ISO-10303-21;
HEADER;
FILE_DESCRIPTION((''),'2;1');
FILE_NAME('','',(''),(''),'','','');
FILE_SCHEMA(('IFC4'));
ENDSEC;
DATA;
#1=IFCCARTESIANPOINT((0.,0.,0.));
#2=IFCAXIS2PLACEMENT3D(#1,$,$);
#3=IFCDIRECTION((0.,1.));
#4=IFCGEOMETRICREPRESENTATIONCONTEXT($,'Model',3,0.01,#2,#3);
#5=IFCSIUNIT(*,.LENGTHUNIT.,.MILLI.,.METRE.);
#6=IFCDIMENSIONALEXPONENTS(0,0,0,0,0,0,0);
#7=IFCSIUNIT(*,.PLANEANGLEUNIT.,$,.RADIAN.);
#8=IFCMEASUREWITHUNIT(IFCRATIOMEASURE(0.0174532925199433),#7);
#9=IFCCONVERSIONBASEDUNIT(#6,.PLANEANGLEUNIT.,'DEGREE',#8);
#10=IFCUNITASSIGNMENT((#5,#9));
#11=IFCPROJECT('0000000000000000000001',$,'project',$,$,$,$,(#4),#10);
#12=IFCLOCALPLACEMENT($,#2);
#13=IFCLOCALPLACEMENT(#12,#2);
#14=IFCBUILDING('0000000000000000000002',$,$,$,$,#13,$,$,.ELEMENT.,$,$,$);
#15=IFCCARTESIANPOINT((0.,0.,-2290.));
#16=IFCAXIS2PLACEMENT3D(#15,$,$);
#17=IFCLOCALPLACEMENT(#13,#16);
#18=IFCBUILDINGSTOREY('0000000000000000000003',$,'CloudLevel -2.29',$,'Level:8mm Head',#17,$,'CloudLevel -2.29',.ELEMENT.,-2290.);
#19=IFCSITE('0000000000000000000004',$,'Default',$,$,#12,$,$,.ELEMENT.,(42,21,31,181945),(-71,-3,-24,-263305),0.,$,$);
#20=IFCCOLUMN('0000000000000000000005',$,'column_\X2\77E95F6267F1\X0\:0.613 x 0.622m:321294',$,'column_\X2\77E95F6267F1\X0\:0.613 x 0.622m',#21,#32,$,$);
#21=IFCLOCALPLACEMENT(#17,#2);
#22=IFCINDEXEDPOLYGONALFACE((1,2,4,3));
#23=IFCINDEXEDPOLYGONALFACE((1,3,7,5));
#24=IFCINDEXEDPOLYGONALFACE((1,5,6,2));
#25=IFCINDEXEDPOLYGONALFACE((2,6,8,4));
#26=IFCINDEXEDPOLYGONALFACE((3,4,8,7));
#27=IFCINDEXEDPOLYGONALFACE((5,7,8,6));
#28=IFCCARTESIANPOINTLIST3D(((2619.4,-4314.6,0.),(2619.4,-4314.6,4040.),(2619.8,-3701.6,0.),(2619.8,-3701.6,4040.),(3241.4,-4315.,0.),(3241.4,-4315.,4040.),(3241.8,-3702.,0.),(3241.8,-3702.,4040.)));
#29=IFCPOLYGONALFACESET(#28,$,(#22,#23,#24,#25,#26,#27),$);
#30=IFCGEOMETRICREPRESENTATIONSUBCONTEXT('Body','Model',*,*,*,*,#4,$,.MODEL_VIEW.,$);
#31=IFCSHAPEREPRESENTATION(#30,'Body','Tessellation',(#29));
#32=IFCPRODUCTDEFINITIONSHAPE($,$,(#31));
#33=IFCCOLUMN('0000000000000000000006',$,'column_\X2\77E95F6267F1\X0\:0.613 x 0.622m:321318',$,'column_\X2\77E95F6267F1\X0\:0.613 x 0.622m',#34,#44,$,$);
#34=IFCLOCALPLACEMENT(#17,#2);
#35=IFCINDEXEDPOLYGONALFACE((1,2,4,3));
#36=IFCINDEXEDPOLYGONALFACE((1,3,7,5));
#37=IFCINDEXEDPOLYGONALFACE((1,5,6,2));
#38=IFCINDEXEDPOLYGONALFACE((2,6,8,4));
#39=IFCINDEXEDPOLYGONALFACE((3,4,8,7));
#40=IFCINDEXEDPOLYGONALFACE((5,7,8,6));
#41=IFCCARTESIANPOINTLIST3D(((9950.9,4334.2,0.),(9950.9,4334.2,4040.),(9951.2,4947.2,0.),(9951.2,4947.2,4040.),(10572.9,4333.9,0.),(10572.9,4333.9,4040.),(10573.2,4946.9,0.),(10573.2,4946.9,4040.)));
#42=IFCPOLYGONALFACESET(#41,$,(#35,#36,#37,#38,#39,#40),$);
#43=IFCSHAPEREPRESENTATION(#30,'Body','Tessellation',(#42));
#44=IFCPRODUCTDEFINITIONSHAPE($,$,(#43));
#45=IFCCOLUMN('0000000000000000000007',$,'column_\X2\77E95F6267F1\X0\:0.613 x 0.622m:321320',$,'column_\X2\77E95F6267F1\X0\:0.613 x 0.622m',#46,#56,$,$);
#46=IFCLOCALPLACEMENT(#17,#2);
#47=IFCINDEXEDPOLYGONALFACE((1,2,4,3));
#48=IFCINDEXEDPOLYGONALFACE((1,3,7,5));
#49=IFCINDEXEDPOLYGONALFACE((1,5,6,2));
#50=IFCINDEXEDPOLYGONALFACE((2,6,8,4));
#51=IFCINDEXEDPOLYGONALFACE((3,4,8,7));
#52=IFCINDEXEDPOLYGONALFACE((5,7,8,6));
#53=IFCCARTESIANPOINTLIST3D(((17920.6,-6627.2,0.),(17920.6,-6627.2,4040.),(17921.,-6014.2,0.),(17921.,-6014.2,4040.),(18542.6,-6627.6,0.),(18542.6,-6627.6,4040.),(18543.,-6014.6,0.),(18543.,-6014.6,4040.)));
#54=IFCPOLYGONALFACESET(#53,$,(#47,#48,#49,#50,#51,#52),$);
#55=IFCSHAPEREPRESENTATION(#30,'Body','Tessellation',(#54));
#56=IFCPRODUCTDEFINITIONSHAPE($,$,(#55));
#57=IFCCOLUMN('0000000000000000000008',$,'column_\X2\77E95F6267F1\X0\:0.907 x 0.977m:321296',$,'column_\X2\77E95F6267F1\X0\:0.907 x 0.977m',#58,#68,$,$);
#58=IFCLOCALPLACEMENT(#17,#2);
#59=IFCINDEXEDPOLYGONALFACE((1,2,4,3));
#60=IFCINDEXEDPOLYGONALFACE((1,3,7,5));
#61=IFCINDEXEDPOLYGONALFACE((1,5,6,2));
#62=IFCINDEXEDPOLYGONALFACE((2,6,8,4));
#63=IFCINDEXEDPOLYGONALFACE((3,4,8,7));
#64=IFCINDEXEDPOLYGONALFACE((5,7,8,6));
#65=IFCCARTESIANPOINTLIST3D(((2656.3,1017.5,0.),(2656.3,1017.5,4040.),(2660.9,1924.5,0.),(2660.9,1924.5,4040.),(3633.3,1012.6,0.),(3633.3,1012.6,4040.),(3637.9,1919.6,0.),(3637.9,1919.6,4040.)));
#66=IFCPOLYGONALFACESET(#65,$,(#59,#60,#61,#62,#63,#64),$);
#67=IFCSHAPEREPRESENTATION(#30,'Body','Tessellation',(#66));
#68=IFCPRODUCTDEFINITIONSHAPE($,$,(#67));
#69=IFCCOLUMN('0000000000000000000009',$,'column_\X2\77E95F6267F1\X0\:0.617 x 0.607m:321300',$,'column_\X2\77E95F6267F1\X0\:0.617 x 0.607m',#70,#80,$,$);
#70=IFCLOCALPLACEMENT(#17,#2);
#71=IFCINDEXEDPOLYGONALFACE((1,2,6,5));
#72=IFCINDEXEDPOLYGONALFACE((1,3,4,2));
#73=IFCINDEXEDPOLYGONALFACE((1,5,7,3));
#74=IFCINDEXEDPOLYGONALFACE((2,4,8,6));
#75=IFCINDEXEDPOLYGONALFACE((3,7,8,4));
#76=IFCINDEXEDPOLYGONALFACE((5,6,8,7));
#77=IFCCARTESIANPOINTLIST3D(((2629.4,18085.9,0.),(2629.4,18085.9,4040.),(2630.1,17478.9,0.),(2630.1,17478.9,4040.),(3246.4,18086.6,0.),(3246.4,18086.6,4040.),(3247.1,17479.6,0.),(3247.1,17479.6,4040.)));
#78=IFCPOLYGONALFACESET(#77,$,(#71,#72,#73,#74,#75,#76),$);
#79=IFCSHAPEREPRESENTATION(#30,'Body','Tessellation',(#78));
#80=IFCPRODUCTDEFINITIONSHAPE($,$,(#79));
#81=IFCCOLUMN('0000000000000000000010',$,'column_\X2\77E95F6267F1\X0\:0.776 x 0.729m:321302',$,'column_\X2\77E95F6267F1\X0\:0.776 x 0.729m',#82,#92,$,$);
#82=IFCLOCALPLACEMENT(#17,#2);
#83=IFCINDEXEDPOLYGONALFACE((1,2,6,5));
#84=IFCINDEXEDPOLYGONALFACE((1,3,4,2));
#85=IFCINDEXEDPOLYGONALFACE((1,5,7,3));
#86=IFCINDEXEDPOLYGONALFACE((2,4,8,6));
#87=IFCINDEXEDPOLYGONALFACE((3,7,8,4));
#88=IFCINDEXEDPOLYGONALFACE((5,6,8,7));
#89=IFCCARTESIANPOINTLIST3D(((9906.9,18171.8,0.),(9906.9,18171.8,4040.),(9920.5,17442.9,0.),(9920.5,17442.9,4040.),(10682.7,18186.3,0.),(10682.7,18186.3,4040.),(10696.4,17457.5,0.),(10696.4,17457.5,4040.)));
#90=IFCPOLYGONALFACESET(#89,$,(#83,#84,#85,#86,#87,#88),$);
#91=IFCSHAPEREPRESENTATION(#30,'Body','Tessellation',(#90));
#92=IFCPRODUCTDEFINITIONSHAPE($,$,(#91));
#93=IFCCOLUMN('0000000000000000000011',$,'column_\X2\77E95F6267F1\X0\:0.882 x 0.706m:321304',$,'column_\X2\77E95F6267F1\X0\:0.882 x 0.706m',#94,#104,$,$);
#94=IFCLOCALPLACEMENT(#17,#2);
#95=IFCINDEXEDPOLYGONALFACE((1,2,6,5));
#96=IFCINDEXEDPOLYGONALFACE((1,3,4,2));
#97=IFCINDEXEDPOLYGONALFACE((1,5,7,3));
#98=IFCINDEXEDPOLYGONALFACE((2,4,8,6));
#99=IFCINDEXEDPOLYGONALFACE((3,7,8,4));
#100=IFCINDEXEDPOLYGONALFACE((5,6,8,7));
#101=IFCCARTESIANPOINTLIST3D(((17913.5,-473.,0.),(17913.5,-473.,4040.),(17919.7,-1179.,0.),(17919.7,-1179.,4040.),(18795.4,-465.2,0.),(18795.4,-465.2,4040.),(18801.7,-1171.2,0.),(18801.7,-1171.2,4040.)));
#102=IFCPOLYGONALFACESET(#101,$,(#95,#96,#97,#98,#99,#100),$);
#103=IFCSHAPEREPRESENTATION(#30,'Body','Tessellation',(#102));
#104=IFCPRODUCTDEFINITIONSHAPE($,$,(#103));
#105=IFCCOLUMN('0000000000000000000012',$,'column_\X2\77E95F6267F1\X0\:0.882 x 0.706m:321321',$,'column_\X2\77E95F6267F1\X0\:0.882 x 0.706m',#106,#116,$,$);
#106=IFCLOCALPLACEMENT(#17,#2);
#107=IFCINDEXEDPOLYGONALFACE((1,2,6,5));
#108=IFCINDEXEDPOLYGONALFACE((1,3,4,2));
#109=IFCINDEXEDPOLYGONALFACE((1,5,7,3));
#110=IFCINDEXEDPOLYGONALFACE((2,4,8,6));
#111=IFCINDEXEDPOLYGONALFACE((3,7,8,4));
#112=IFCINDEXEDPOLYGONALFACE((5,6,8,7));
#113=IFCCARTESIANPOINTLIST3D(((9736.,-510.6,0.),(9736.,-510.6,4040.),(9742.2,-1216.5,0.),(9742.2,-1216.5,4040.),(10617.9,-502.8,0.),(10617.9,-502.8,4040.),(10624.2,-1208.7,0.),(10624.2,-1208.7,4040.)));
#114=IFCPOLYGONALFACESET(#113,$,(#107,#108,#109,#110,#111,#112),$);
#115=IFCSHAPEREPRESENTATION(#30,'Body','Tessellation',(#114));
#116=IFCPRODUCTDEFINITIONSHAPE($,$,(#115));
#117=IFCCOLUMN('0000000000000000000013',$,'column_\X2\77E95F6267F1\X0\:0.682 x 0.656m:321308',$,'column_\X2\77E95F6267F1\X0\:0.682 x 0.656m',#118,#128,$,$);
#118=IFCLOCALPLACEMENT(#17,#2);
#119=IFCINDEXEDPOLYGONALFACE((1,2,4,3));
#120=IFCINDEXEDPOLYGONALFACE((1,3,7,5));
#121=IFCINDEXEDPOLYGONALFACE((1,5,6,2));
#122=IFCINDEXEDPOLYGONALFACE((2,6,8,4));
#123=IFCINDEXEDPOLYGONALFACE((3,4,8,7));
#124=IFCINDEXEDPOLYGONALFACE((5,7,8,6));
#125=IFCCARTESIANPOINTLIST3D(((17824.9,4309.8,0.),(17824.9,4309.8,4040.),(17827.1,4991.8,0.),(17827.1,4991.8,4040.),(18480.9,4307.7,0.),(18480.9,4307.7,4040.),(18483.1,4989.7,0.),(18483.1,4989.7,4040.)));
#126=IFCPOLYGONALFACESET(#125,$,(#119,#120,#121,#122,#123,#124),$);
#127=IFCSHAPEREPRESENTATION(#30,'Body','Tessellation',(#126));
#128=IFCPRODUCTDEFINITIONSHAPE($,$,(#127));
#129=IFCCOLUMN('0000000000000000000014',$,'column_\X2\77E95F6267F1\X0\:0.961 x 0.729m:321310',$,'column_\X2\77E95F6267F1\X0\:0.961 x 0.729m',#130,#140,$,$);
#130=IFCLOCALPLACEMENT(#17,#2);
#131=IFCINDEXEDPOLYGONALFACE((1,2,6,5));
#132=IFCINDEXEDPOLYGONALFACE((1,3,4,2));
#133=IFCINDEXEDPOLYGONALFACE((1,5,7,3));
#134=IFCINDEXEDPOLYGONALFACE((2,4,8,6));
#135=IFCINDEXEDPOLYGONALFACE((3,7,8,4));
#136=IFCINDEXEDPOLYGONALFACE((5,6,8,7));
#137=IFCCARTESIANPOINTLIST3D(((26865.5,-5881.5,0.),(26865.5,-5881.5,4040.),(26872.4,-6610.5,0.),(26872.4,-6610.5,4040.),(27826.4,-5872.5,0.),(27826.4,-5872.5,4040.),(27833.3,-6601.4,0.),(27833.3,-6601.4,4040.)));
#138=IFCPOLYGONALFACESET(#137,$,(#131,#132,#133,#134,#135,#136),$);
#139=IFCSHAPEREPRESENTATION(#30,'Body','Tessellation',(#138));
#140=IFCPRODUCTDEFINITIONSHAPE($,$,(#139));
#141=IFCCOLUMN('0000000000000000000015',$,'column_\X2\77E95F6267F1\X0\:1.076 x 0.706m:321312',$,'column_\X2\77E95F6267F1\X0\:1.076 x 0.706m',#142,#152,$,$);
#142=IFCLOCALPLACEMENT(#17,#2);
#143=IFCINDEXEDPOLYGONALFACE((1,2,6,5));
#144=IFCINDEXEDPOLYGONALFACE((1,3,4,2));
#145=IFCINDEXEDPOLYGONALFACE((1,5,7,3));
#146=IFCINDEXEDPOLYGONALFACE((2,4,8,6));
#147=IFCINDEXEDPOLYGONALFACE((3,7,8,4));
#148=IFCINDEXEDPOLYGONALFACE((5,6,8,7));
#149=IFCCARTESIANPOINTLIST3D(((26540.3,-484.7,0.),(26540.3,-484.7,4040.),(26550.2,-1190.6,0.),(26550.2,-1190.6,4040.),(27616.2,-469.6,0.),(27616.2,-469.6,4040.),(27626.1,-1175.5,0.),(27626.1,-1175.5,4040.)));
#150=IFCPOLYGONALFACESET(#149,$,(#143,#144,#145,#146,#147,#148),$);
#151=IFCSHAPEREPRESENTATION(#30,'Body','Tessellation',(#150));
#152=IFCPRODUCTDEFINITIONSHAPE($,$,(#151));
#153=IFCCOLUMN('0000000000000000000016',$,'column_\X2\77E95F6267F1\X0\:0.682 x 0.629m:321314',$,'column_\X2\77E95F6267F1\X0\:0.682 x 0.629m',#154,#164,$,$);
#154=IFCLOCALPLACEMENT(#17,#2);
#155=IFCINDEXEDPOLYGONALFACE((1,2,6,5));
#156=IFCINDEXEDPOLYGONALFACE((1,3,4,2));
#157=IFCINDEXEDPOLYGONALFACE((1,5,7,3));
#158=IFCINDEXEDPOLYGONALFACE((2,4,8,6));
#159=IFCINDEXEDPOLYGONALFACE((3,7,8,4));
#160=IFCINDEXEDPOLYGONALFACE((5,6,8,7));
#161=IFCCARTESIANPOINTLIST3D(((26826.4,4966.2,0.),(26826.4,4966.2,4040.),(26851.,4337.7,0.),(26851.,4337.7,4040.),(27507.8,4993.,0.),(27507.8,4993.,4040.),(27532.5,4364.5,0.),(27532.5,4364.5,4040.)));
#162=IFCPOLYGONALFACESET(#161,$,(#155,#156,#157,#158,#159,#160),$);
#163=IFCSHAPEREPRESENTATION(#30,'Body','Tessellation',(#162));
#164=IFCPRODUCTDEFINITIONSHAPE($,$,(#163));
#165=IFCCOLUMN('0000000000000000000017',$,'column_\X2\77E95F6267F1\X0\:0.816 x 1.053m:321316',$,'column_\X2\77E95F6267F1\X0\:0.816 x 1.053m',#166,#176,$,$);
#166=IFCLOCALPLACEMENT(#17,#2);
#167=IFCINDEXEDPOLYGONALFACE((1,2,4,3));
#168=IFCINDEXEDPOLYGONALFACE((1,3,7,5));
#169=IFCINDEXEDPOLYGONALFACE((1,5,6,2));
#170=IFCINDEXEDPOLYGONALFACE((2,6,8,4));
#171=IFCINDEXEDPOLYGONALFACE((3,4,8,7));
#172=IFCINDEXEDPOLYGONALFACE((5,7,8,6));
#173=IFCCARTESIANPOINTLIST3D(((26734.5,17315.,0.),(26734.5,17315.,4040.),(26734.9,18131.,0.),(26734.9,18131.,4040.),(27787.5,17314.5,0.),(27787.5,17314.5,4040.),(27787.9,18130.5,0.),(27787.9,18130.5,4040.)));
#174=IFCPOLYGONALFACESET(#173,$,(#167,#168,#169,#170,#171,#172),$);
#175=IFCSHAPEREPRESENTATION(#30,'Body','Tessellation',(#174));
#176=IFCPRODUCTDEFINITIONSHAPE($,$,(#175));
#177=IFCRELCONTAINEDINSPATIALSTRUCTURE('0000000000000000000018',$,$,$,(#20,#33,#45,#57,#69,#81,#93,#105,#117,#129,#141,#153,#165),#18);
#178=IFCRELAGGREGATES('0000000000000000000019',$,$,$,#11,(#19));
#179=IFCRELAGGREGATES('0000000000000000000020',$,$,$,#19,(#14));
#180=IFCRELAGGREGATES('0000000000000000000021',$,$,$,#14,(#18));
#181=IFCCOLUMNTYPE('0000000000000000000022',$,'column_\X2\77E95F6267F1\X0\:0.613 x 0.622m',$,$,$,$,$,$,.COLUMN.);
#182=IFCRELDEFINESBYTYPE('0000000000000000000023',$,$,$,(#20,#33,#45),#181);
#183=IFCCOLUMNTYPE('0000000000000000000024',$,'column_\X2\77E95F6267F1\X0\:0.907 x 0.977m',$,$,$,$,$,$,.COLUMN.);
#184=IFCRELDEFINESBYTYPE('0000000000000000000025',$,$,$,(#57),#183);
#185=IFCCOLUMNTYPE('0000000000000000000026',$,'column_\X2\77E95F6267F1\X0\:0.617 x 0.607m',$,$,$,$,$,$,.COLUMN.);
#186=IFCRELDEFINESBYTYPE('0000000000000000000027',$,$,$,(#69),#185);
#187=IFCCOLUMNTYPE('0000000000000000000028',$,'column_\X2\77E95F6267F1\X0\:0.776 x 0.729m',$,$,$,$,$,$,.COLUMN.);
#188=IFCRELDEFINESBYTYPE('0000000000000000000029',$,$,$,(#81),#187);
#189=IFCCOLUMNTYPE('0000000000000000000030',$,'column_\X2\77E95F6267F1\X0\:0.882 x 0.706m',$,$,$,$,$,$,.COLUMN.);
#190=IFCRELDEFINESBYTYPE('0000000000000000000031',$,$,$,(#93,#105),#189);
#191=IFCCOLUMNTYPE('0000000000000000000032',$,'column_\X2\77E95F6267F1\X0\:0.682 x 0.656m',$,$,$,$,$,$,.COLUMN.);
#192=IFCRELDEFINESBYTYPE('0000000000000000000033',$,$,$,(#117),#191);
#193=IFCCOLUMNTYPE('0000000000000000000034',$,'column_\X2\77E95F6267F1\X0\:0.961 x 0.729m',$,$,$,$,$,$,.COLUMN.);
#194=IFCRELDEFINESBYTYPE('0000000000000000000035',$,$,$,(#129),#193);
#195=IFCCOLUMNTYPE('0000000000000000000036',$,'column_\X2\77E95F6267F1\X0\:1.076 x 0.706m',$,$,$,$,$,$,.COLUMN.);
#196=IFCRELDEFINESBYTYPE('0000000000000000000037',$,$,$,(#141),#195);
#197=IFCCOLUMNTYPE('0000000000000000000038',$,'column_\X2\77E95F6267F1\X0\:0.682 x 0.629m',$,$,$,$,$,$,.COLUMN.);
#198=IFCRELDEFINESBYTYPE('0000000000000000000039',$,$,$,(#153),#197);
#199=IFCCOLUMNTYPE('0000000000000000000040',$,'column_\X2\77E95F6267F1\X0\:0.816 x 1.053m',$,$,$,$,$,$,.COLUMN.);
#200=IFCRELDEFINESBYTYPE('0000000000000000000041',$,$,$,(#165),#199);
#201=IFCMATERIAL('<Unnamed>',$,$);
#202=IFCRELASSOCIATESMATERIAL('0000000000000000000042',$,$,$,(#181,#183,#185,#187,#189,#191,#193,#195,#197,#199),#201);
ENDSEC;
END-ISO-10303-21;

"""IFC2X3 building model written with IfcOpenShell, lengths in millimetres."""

from ifc_helpers import new_model, entity, si_unit, converted_unit, direction, frame, origin, origin_2d_with_axis, place, context, subcontext, project, spatial, rectangle, extrude, source, transform, mapped, material, type_object, type_shapes, element, save


model = new_model("IFC2X3")

# Units and contexts
model_context = context("Model", 3, precision=0.01, world=origin(), true_north=direction((0.0, 1.0)))
body_context = subcontext(model_context, "Body", "Model", "MODEL_VIEW")
ifc_project = project(units=[si_unit("LENGTHUNIT", "METRE", prefix="MILLI"), converted_unit("PLANEANGLEUNIT", "DEGREE", entity("IfcRatioMeasure", 0.0174532925199433), si_unit("PLANEANGLEUNIT", "RADIAN"), dimensions=[0, 0, 0, 0, 0, 0, 0])], contexts=[model_context])

# Site, building, storey
site_placement = place(None, origin())
site = spatial("IfcSite", under=ifc_project, at=site_placement, Name="Default", CompositionType="ELEMENT", RefLatitude=(42, 21, 31, 181945), RefLongitude=(-71, -3, -24, -263305), RefElevation=0.0)
building_placement = place(site_placement, origin())
building = spatial("IfcBuilding", under=site, at=building_placement, CompositionType="ELEMENT")
storey_placement = place(building_placement, frame((0.0, 0.0, -2290.0)))
storey = spatial("IfcBuildingStorey", under=building, at=storey_placement, Name="CloudLevel -2.29", ObjectType="Level:8mm Head", LongName="CloudLevel -2.29", CompositionType="ELEMENT", Elevation=-2290.0)

# Columns
ifc_material_1 = material(Name="<Unnamed>")
column_type_1 = type_object("IfcColumnType", Name="column_矩形柱:0.613 x 0.622m", PredefinedType="COLUMN", material=ifc_material_1)
shared_shape_1 = source(origin(), body_context, "Body", "SweptSolid", [
    extrude(rectangle(XDim=622.0, YDim=613.0, at=origin_2d_with_axis()), frame((0.0, 0.0, -2290.0), z_axis=(0.0, 0.0, 1.0), x_axis=(0.0, -1.0, 0.0)), (0.0, 0.0, 1.0), 4040.0),
])
type_shapes(column_type_1, [shared_shape_1])
for number, where, z_axis, x_axis, name in (
    (1, (2930.6, -4008.3, 2290.0), (0.0, 0.0, 1.0), (0.000573, 1.0, 0.0), "column_矩形柱:0.613 x 0.622m:321294"),
    (2, (10262.1, 4640.6, 2290.0), (0.0, 0.0, 1.0), (0.000573, 1.0, 0.0), "column_矩形柱:0.613 x 0.622m:321318"),
    (3, (18231.8, -6320.9, 2290.0), (0.0, 0.0, 1.0), (0.000573, 1.0, 0.0), "column_矩形柱:0.613 x 0.622m:321320"),
):
    element("IfcColumn", number, at=place(storey_placement, frame(where, z_axis=z_axis, x_axis=x_axis)), inside=storey, type_object=column_type_1, Name=name, ObjectType="column_矩形柱:0.613 x 0.622m", context=body_context, shape_type="MappedRepresentation", body=[
        mapped(shared_shape_1, transform((0.0, 0.0, 0.0), scale=1.0)),
    ])
column_type_2 = type_object("IfcColumnType", Name="column_矩形柱:0.907 x 0.977m", PredefinedType="COLUMN", material=ifc_material_1)
shared_shape_2 = source(origin(), body_context, "Body", "SweptSolid", [
    extrude(rectangle(XDim=977.0, YDim=907.0, at=origin_2d_with_axis()), frame((0.0, 0.0, -2290.0), z_axis=(0.0, 0.0, 1.0), x_axis=(0.0, -1.0, 0.0)), (0.0, 0.0, 1.0), 4040.0),
])
type_shapes(column_type_2, [shared_shape_2])
column_1_placement = place(storey_placement, frame((3147.1, 1468.6, 2290.0), z_axis=(0.0, 0.0, 1.0), x_axis=(0.005033, 0.999987, 0.0)))
element("IfcColumn", 4, at=column_1_placement, inside=storey, type_object=column_type_2, Name="column_矩形柱:0.907 x 0.977m:321296", ObjectType="column_矩形柱:0.907 x 0.977m", context=body_context, shape_type="MappedRepresentation", body=[
    mapped(shared_shape_2, transform((0.0, 0.0, 0.0), scale=1.0)),
])
column_type_3 = type_object("IfcColumnType", Name="column_矩形柱:0.617 x 0.607m", PredefinedType="COLUMN", material=ifc_material_1)
shared_shape_3 = source(origin(), body_context, "Body", "SweptSolid", [
    extrude(rectangle(XDim=607.0, YDim=617.0, at=origin_2d_with_axis()), frame((0.0, 0.0, -2290.0), z_axis=(0.0, 0.0, 1.0), x_axis=(0.0, -1.0, 0.0)), (0.0, 0.0, 1.0), 4040.0),
])
type_shapes(column_type_3, [shared_shape_3])
column_2_placement = place(storey_placement, frame((2938.3, 17782.8, 2290.0), z_axis=(0.0, 0.0, 1.0), x_axis=(0.999999, 0.001037, 0.0)))
element("IfcColumn", 5, at=column_2_placement, inside=storey, type_object=column_type_3, Name="column_矩形柱:0.617 x 0.607m:321300", ObjectType="column_矩形柱:0.617 x 0.607m", context=body_context, shape_type="MappedRepresentation", body=[
    mapped(shared_shape_3, transform((0.0, 0.0, 0.0), scale=1.0)),
])
column_type_4 = type_object("IfcColumnType", Name="column_矩形柱:0.776 x 0.729m", PredefinedType="COLUMN", material=ifc_material_1)
shared_shape_4 = source(origin(), body_context, "Body", "SweptSolid", [
    extrude(rectangle(XDim=729.0, YDim=776.0, at=origin_2d_with_axis()), frame((0.0, 0.0, -2290.0), z_axis=(0.0, 0.0, 1.0), x_axis=(0.0, -1.0, 0.0)), (0.0, 0.0, 1.0), 4040.0),
])
type_shapes(column_type_4, [shared_shape_4])
column_3_placement = place(storey_placement, frame((10301.6, 17814.6, 2290.0), z_axis=(0.0, 0.0, 1.0), x_axis=(0.999825, 0.018709, 0.0)))
element("IfcColumn", 6, at=column_3_placement, inside=storey, type_object=column_type_4, Name="column_矩形柱:0.776 x 0.729m:321302", ObjectType="column_矩形柱:0.776 x 0.729m", context=body_context, shape_type="MappedRepresentation", body=[
    mapped(shared_shape_4, transform((0.0, 0.0, 0.0), scale=1.0)),
])
column_type_5 = type_object("IfcColumnType", Name="column_矩形柱:0.882 x 0.706m", PredefinedType="COLUMN", material=ifc_material_1)
shared_shape_5 = source(origin(), body_context, "Body", "SweptSolid", [
    extrude(rectangle(XDim=706.0, YDim=882.0, at=origin_2d_with_axis()), frame((0.0, 0.0, -2290.0), z_axis=(0.0, 0.0, 1.0), x_axis=(0.0, -1.0, 0.0)), (0.0, 0.0, 1.0), 4040.0),
])
type_shapes(column_type_5, [shared_shape_5])
for number, where, z_axis, x_axis, name in (
    (7, (18357.6, -822.1, 2290.0), (0.0, 0.0, 1.0), (0.999961, 0.008846, 0.0), "column_矩形柱:0.882 x 0.706m:321304"),
    (8, (10180.1, -859.6, 2290.0), (0.0, 0.0, 1.0), (0.999961, 0.008846, 0.0), "column_矩形柱:0.882 x 0.706m:321321"),
):
    element("IfcColumn", number, at=place(storey_placement, frame(where, z_axis=z_axis, x_axis=x_axis)), inside=storey, type_object=column_type_5, Name=name, ObjectType="column_矩形柱:0.882 x 0.706m", context=body_context, shape_type="MappedRepresentation", body=[
        mapped(shared_shape_5, transform((0.0, 0.0, 0.0), scale=1.0)),
    ])
column_type_6 = type_object("IfcColumnType", Name="column_矩形柱:0.682 x 0.656m", PredefinedType="COLUMN", material=ifc_material_1)
shared_shape_6 = source(origin(), body_context, "Body", "SweptSolid", [
    extrude(rectangle(XDim=656.0, YDim=682.0, at=origin_2d_with_axis()), frame((0.0, 0.0, -2290.0), z_axis=(0.0, 0.0, 1.0), x_axis=(0.0, -1.0, 0.0)), (0.0, 0.0, 1.0), 4040.0),
])
type_shapes(column_type_6, [shared_shape_6])
column_4_placement = place(storey_placement, frame((18154.0, 4649.8, 2290.0), z_axis=(0.0, 0.0, 1.0), x_axis=(0.003213, 0.999995, 0.0)))
element("IfcColumn", 9, at=column_4_placement, inside=storey, type_object=column_type_6, Name="column_矩形柱:0.682 x 0.656m:321308", ObjectType="column_矩形柱:0.682 x 0.656m", context=body_context, shape_type="MappedRepresentation", body=[
    mapped(shared_shape_6, transform((0.0, 0.0, 0.0), scale=1.0)),
])
column_type_7 = type_object("IfcColumnType", Name="column_矩形柱:0.961 x 0.729m", PredefinedType="COLUMN", material=ifc_material_1)
shared_shape_7 = source(origin(), body_context, "Body", "SweptSolid", [
    extrude(rectangle(XDim=729.0, YDim=961.0, at=origin_2d_with_axis()), frame((0.0, 0.0, -2290.0), z_axis=(0.0, 0.0, 1.0), x_axis=(0.0, -1.0, 0.0)), (0.0, 0.0, 1.0), 4040.0),
])
type_shapes(column_type_7, [shared_shape_7])
column_5_placement = place(storey_placement, frame((27349.4, -6241.5, 2290.0), z_axis=(0.0, 0.0, 1.0), x_axis=(0.999955, 0.009459, 0.0)))
element("IfcColumn", 10, at=column_5_placement, inside=storey, type_object=column_type_7, Name="column_矩形柱:0.961 x 0.729m:321310", ObjectType="column_矩形柱:0.961 x 0.729m", context=body_context, shape_type="MappedRepresentation", body=[
    mapped(shared_shape_7, transform((0.0, 0.0, 0.0), scale=1.0)),
])
column_type_8 = type_object("IfcColumnType", Name="column_矩形柱:1.076 x 0.706m", PredefinedType="COLUMN", material=ifc_material_1)
shared_shape_8 = source(origin(), body_context, "Body", "SweptSolid", [
    extrude(rectangle(XDim=706.0, YDim=1076.0, at=origin_2d_with_axis()), frame((0.0, 0.0, -2290.0), z_axis=(0.0, 0.0, 1.0), x_axis=(0.0, -1.0, 0.0)), (0.0, 0.0, 1.0), 4040.0),
])
type_shapes(column_type_8, [shared_shape_8])
column_6_placement = place(storey_placement, frame((27083.2, -830.1, 2290.0), z_axis=(0.0, 0.0, 1.0), x_axis=(0.999902, 0.014012, 0.0)))
element("IfcColumn", 11, at=column_6_placement, inside=storey, type_object=column_type_8, Name="column_矩形柱:1.076 x 0.706m:321312", ObjectType="column_矩形柱:1.076 x 0.706m", context=body_context, shape_type="MappedRepresentation", body=[
    mapped(shared_shape_8, transform((0.0, 0.0, 0.0), scale=1.0)),
])
column_type_9 = type_object("IfcColumnType", Name="column_矩形柱:0.682 x 0.629m", PredefinedType="COLUMN", material=ifc_material_1)
shared_shape_9 = source(origin(), body_context, "Body", "SweptSolid", [
    extrude(rectangle(XDim=629.0, YDim=682.0, at=origin_2d_with_axis()), frame((0.0, 0.0, -2290.0), z_axis=(0.0, 0.0, 1.0), x_axis=(0.0, -1.0, 0.0)), (0.0, 0.0, 1.0), 4040.0),
])
type_shapes(column_type_9, [shared_shape_9])
column_7_placement = place(storey_placement, frame((27179.4, 4665.3, 2290.0), z_axis=(0.0, 0.0, 1.0), x_axis=(0.999231, 0.03922, 0.0)))
element("IfcColumn", 12, at=column_7_placement, inside=storey, type_object=column_type_9, Name="column_矩形柱:0.682 x 0.629m:321314", ObjectType="column_矩形柱:0.682 x 0.629m", context=body_context, shape_type="MappedRepresentation", body=[
    mapped(shared_shape_9, transform((0.0, 0.0, 0.0), scale=1.0)),
])
column_type_10 = type_object("IfcColumnType", Name="column_矩形柱:0.816 x 1.053m", PredefinedType="COLUMN", material=ifc_material_1)
shared_shape_10 = source(origin(), body_context, "Body", "SweptSolid", [
    extrude(rectangle(XDim=1053.0, YDim=816.0, at=origin_2d_with_axis()), frame((0.0, 0.0, -2290.0), z_axis=(0.0, 0.0, 1.0), x_axis=(0.0, -1.0, 0.0)), (0.0, 0.0, 1.0), 4040.0),
])
type_shapes(column_type_10, [shared_shape_10])
column_8_placement = place(storey_placement, frame((27261.2, 17722.7, 2290.0), z_axis=(0.0, 0.0, 1.0), x_axis=(0.000485, 1.0, 0.0)))
element("IfcColumn", 13, at=column_8_placement, inside=storey, type_object=column_type_10, Name="column_矩形柱:0.816 x 1.053m:321316", ObjectType="column_矩形柱:0.816 x 1.053m", context=body_context, shape_type="MappedRepresentation", body=[
    mapped(shared_shape_10, transform((0.0, 0.0, 0.0), scale=1.0)),
])

save(model, "model.ifc")
